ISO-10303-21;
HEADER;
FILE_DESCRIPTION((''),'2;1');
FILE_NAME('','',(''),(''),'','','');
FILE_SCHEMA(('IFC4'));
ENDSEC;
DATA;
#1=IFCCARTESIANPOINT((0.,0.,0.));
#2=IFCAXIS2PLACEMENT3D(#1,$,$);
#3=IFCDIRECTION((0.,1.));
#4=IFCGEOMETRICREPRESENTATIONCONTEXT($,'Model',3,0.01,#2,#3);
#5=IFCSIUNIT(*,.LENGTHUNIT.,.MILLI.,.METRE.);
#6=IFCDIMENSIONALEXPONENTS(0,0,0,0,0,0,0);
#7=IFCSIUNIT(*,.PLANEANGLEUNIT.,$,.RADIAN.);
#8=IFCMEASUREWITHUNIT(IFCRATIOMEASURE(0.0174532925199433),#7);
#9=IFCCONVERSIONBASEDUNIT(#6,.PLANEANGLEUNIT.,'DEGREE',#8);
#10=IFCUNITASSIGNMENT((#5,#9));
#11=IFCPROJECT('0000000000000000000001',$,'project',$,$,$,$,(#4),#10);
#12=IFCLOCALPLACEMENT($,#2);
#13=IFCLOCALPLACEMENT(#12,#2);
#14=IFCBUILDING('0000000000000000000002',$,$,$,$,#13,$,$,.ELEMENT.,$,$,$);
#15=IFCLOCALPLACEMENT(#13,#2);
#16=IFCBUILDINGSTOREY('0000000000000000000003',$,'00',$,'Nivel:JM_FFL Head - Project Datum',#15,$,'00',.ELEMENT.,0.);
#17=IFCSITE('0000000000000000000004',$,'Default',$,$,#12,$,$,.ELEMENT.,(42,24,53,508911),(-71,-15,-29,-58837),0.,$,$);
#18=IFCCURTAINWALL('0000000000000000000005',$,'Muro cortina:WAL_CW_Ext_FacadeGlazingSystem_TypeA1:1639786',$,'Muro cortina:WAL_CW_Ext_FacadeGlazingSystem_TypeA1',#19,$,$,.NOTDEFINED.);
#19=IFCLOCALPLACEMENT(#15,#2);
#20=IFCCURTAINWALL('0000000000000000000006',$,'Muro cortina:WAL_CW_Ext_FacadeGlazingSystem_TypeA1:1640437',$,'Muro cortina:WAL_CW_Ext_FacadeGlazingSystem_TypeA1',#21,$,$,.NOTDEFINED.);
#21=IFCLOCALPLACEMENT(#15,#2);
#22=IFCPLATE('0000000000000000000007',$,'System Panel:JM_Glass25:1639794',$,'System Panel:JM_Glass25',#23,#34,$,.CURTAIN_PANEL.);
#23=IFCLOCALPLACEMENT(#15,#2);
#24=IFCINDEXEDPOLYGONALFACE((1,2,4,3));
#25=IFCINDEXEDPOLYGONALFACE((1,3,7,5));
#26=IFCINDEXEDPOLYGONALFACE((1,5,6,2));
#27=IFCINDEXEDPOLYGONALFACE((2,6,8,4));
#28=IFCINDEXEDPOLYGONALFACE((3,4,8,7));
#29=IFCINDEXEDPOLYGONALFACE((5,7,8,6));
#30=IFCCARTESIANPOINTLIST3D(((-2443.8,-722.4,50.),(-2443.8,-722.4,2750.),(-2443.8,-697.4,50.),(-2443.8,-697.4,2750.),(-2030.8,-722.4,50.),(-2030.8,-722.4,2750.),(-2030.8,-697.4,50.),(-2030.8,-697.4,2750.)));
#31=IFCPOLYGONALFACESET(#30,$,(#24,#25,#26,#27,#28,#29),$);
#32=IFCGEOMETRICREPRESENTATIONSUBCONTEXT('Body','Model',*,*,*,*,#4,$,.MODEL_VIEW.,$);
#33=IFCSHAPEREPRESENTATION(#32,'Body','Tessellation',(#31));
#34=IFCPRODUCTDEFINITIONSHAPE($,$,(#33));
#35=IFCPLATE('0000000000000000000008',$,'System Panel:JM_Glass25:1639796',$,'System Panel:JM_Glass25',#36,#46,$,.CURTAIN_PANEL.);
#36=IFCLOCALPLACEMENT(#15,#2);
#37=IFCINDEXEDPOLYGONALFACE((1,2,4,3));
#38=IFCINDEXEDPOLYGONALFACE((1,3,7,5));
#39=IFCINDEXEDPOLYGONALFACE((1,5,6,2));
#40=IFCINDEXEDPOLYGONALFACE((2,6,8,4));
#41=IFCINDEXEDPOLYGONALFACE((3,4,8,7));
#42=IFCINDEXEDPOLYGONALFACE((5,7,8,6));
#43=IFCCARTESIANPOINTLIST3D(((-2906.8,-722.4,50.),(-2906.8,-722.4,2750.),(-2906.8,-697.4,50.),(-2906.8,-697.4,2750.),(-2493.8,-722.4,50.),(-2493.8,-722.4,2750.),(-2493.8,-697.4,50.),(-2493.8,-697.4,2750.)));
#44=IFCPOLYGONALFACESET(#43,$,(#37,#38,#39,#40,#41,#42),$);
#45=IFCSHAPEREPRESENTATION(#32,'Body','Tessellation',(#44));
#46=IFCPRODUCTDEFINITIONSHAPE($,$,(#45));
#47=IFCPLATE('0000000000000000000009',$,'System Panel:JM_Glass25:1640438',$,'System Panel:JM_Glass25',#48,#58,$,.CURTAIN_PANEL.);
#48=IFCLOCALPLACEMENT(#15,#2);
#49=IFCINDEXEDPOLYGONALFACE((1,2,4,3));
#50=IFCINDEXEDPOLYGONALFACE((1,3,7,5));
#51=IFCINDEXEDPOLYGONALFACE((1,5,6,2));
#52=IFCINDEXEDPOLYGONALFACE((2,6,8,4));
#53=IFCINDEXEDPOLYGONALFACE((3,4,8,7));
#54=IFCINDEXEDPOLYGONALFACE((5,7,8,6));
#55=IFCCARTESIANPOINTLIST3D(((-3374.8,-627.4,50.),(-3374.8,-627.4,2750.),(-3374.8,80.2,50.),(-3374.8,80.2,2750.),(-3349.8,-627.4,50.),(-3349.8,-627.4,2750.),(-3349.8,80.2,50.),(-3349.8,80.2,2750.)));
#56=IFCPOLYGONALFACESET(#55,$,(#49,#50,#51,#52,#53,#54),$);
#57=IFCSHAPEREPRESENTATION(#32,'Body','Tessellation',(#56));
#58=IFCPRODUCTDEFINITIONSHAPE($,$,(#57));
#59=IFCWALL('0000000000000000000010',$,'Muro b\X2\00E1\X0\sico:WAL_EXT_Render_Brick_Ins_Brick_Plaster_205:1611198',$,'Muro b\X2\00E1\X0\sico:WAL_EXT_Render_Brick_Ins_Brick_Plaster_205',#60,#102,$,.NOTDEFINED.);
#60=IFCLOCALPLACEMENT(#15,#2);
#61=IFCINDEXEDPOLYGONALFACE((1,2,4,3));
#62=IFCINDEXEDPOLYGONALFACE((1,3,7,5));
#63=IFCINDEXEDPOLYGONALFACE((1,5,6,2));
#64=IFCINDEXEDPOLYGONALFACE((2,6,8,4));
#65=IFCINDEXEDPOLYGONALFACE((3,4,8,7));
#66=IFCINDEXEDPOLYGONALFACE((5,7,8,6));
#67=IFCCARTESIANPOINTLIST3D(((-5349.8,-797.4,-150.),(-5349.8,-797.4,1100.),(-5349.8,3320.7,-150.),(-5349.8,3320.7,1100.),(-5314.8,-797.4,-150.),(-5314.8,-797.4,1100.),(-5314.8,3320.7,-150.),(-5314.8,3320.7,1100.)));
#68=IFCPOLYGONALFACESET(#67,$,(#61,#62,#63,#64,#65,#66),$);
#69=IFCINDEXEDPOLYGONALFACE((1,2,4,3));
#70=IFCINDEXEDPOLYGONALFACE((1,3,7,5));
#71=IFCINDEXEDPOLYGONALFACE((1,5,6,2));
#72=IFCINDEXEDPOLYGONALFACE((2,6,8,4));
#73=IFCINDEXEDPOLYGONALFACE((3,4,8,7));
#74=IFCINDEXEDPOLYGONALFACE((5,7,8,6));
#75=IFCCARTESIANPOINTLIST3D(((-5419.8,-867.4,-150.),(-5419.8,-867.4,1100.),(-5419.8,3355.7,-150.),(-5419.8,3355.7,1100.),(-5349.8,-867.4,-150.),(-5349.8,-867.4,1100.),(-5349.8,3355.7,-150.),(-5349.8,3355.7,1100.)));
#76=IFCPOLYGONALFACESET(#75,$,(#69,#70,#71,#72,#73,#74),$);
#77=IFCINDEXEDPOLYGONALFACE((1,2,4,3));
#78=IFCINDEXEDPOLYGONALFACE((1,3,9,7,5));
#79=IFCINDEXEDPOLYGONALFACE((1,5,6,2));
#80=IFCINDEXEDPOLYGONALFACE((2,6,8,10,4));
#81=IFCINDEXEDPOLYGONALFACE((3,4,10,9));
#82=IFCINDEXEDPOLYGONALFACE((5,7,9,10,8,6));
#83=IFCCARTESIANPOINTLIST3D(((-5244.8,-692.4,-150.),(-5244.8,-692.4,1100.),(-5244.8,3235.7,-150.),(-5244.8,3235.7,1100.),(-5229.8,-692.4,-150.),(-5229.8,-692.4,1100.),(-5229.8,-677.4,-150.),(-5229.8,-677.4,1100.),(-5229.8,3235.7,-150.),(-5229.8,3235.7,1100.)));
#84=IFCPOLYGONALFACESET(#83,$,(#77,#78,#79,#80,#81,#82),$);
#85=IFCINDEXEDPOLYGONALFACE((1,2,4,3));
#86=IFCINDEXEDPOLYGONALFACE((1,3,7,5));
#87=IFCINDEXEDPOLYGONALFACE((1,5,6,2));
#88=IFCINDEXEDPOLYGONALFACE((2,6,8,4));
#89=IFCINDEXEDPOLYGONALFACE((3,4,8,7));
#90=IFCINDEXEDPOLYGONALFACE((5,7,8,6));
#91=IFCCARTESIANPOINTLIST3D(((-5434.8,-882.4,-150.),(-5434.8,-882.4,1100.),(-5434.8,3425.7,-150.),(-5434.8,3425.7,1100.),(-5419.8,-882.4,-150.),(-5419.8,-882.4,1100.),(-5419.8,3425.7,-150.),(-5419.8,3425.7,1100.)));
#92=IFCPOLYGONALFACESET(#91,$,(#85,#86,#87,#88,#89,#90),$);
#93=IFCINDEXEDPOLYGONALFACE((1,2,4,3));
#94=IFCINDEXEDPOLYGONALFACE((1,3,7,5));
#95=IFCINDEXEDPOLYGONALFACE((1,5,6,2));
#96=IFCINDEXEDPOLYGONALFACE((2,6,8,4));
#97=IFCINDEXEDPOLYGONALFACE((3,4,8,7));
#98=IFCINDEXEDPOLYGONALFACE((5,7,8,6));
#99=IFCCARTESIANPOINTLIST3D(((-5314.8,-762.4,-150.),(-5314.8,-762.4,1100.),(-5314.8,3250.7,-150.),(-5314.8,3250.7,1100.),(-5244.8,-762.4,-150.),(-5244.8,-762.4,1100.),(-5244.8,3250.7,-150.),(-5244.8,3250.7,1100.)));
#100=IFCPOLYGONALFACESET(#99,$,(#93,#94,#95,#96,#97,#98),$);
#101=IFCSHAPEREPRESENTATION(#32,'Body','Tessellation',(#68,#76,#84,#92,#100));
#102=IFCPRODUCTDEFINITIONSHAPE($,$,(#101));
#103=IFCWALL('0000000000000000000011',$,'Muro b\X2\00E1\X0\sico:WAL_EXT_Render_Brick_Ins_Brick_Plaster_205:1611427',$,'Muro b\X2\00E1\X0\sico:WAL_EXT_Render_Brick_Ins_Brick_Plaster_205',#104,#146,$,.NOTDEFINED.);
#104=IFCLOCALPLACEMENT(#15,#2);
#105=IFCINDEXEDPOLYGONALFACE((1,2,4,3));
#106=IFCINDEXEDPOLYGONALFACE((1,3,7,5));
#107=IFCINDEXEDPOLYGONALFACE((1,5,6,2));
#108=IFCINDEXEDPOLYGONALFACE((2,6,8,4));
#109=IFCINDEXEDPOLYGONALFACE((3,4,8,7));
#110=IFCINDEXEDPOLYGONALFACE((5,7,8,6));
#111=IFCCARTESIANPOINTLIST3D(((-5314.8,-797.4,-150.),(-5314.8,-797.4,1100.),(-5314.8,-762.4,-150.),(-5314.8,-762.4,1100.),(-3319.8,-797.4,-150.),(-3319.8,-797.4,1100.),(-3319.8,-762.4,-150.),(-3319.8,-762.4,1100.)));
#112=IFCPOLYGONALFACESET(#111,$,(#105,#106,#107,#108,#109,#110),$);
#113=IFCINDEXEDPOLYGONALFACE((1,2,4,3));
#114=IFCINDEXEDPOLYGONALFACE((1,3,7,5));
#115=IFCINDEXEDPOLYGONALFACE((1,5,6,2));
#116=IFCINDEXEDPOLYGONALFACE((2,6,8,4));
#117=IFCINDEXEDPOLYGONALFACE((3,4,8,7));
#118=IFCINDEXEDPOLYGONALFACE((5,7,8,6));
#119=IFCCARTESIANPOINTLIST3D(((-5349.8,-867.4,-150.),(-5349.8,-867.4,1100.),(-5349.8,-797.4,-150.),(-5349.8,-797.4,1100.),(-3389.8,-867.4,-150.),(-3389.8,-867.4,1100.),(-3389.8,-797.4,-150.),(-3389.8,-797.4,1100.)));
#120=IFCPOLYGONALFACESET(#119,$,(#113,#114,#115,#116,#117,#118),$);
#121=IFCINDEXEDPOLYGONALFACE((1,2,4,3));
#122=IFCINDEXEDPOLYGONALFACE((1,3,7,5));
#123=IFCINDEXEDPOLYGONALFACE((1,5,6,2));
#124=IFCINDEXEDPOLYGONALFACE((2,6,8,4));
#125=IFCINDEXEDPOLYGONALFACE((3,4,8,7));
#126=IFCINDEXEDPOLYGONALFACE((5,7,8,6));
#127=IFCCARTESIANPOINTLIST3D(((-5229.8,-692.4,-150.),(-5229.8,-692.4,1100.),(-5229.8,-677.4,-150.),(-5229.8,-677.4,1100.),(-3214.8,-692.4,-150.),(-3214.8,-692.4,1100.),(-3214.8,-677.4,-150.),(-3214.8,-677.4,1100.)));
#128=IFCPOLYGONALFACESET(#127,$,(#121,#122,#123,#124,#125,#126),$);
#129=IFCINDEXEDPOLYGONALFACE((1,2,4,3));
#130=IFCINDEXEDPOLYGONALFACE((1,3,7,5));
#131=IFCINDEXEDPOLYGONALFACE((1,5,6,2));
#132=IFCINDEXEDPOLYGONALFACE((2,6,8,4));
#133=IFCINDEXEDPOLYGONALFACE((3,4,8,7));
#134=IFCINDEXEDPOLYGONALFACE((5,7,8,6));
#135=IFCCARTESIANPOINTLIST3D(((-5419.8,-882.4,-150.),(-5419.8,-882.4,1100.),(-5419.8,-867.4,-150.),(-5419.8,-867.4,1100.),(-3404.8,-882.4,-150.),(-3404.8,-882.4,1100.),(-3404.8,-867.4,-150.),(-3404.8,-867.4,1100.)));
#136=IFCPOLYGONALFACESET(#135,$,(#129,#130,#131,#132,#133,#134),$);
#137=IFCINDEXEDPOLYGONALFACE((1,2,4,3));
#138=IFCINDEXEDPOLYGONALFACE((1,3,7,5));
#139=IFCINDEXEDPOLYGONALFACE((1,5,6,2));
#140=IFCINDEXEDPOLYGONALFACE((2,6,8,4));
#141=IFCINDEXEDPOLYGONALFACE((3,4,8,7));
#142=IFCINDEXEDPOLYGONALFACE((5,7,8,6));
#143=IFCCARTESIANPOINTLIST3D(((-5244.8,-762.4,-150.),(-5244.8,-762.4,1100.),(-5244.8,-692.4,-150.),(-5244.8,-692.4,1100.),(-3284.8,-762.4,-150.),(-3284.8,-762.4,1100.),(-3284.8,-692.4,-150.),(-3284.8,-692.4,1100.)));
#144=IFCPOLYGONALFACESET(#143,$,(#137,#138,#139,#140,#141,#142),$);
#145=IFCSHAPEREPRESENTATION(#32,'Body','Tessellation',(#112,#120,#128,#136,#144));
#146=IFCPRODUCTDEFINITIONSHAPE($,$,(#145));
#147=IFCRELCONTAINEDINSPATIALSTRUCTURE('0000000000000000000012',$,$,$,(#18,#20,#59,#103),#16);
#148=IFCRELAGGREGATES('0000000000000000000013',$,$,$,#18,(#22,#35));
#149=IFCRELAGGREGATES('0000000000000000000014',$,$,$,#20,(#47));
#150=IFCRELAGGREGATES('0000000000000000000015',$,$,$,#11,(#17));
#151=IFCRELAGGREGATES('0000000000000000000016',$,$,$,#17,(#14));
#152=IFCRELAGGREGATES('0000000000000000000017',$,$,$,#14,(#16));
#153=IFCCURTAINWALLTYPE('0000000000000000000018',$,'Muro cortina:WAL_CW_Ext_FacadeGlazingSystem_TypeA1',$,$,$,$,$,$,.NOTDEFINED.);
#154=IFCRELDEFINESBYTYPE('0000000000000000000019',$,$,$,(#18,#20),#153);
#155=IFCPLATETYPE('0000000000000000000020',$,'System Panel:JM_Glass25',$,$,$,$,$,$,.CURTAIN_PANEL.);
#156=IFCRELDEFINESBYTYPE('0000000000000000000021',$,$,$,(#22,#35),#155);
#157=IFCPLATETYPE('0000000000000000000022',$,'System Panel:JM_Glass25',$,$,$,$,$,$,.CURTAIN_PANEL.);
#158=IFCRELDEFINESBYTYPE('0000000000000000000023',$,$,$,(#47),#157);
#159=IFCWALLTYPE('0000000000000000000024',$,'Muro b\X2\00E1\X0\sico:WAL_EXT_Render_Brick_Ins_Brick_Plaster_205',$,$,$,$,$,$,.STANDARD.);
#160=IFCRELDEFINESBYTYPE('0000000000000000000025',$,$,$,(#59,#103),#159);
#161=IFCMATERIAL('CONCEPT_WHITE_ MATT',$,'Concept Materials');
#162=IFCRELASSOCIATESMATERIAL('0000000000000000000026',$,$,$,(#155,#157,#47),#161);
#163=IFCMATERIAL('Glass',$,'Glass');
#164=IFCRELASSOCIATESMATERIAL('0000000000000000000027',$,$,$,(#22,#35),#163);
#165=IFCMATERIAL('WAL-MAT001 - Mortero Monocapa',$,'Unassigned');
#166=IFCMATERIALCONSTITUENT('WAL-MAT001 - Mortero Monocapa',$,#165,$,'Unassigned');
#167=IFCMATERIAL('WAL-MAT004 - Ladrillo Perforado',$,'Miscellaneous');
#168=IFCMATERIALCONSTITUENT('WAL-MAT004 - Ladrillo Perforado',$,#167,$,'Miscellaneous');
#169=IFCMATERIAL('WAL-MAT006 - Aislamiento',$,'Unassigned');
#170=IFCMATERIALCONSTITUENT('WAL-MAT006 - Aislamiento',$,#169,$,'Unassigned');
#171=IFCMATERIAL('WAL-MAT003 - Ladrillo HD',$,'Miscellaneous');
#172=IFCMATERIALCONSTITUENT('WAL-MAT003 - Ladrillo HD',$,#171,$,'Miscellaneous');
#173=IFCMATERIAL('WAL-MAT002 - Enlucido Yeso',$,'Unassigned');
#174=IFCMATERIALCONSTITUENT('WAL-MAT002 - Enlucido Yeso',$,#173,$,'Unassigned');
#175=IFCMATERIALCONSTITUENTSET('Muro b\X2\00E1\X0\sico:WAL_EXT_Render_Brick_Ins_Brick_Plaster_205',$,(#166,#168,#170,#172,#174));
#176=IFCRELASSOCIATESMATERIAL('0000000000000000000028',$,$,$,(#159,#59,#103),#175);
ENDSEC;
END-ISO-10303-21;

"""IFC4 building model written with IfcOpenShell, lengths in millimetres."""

from ifc_helpers import new_model, entity, si_unit, converted_unit, direction, frame, origin, place, context, subcontext, project, spatial, indexed_curve, outline, extrude, source, transform, mapped, material, constituent, constituent_set, type_object, type_shapes, element, aggregate, save


model = new_model("IFC4")

# Units and contexts
model_context = context("Model", 3, precision=0.01, world=origin(), true_north=direction((0.0, 1.0)))
body_context = subcontext(model_context, "Body", "Model", "MODEL_VIEW")
ifc_project = project(units=[si_unit("LENGTHUNIT", "METRE", prefix="MILLI"), converted_unit("PLANEANGLEUNIT", "DEGREE", entity("IfcRatioMeasure", 0.0174532925199433), si_unit("PLANEANGLEUNIT", "RADIAN"), dimensions=[0, 0, 0, 0, 0, 0, 0])], contexts=[model_context])

# Site, building, storey
site_placement = place(None, origin())
site = spatial("IfcSite", under=ifc_project, at=site_placement, Name="Default", CompositionType="ELEMENT", RefLatitude=(42, 24, 53, 508911), RefLongitude=(-71, -15, -29, -58837), RefElevation=0.0)
building_placement = place(site_placement, origin())
building = spatial("IfcBuilding", under=site, at=building_placement, CompositionType="ELEMENT")
storey_placement = place(building_placement, origin())
storey = spatial("IfcBuildingStorey", under=building, at=storey_placement, Name="00", ObjectType="Nivel:JM_FFL Head - Project Datum", LongName="00", CompositionType="ELEMENT", Elevation=0.0)

# Curtain wall
curtain_wall_type = type_object("IfcCurtainWallType", Name="Muro cortina:WAL_CW_Ext_FacadeGlazingSystem_TypeA1", PredefinedType="NOTDEFINED")
curtain_wall_1_placement = place(storey_placement, origin())
curtain_wall_1 = element("IfcCurtainWall", 1, at=curtain_wall_1_placement, inside=storey, type_object=curtain_wall_type, Name="Muro cortina:WAL_CW_Ext_FacadeGlazingSystem_TypeA1:1639786", ObjectType="Muro cortina:WAL_CW_Ext_FacadeGlazingSystem_TypeA1", PredefinedType="NOTDEFINED")

# Curtain wall
curtain_wall_2_placement = place(storey_placement, origin())
curtain_wall_2 = element("IfcCurtainWall", 2, at=curtain_wall_2_placement, inside=storey, type_object=curtain_wall_type, Name="Muro cortina:WAL_CW_Ext_FacadeGlazingSystem_TypeA1:1640437", ObjectType="Muro cortina:WAL_CW_Ext_FacadeGlazingSystem_TypeA1", PredefinedType="NOTDEFINED")

# Plates
ifc_material_1 = material(Name="Glass", Category="Glass")
ifc_material_2 = material(Name="CONCEPT_WHITE_ MATT", Category="Concept Materials")
plate_type_1 = type_object("IfcPlateType", Name="System Panel:JM_Glass25", PredefinedType="CURTAIN_PANEL", material=ifc_material_2)
shared_shape_1 = source(origin(), body_context, "Body", "SweptSolid", [
    extrude(outline(indexed_curve([(-12.5, -206.5), (12.5, -206.5), (12.5, 206.5), (-12.5, 206.5), (-12.5, -206.5)], self_intersect=False)), frame((0.0, 32.5, 0.0), z_axis=(0.0, 0.0, 1.0), x_axis=(0.0, 1.0, 0.0)), (0.0, 0.0, 1.0), 2700.0),
])
type_shapes(plate_type_1, [shared_shape_1])
plate_1_placement = place(curtain_wall_1_placement, frame((-2237.3, -677.4, 50.0), z_axis=(0.0, 0.0, 1.0), x_axis=(-1.0, 0.0, 0.0)))
plate_1 = element("IfcPlate", 3, at=plate_1_placement, type_object=plate_type_1, material=ifc_material_1, Name="System Panel:JM_Glass25:1639794", ObjectType="System Panel:JM_Glass25", PredefinedType="CURTAIN_PANEL", context=body_context, shape_type="MappedRepresentation", body=[
    mapped(shared_shape_1, transform((0.0, 0.0, 0.0), scale=1.0)),
])
plate_2_placement = place(curtain_wall_1_placement, frame((-2700.3, -677.4, 50.0), z_axis=(0.0, 0.0, 1.0), x_axis=(-1.0, 0.0, 0.0)))
plate_2 = element("IfcPlate", 4, at=plate_2_placement, type_object=plate_type_1, material=ifc_material_1, Name="System Panel:JM_Glass25:1639796", ObjectType="System Panel:JM_Glass25", PredefinedType="CURTAIN_PANEL", context=body_context, shape_type="MappedRepresentation", body=[
    mapped(shared_shape_1, transform((0.0, 0.0, 0.0), scale=1.0)),
])
aggregate(curtain_wall_1, [plate_1, plate_2])
plate_type_2 = type_object("IfcPlateType", Name="System Panel:JM_Glass25", PredefinedType="CURTAIN_PANEL", material=ifc_material_2)
shared_shape_2 = source(origin(), body_context, "Body", "SweptSolid", [
    extrude(outline(indexed_curve([(-12.5, -353.8), (12.5, -353.8), (12.5, 353.8), (-12.5, 353.8), (-12.5, -353.8)], self_intersect=False)), frame((0.0, 32.5, 0.0), z_axis=(0.0, 0.0, 1.0), x_axis=(0.0, 1.0, 0.0)), (0.0, 0.0, 1.0), 2700.0),
])
type_shapes(plate_type_2, [shared_shape_2])
plate_3_placement = place(curtain_wall_2_placement, frame((-3329.8, -273.6, 50.0), z_axis=(0.0, 0.0, 1.0), x_axis=(0.0, 1.0, 0.0)))
plate_3 = element("IfcPlate", 5, at=plate_3_placement, type_object=plate_type_2, material=ifc_material_2, Name="System Panel:JM_Glass25:1640438", ObjectType="System Panel:JM_Glass25", PredefinedType="CURTAIN_PANEL", context=body_context, shape_type="MappedRepresentation", body=[
    mapped(shared_shape_2, transform((0.0, 0.0, 0.0), scale=1.0)),
])
aggregate(curtain_wall_2, [plate_3])

# Walls
ifc_material_3 = material(Name="WAL-MAT001 - Mortero Monocapa", Category="Unassigned")
ifc_constituent_1 = constituent(ifc_material_3, Name="WAL-MAT001 - Mortero Monocapa", Category="Unassigned")
ifc_material_4 = material(Name="WAL-MAT004 - Ladrillo Perforado", Category="Miscellaneous")
ifc_constituent_2 = constituent(ifc_material_4, Name="WAL-MAT004 - Ladrillo Perforado", Category="Miscellaneous")
ifc_material_5 = material(Name="WAL-MAT006 - Aislamiento", Category="Unassigned")
ifc_constituent_3 = constituent(ifc_material_5, Name="WAL-MAT006 - Aislamiento", Category="Unassigned")
ifc_material_6 = material(Name="WAL-MAT003 - Ladrillo HD", Category="Miscellaneous")
ifc_constituent_4 = constituent(ifc_material_6, Name="WAL-MAT003 - Ladrillo HD", Category="Miscellaneous")
ifc_material_7 = material(Name="WAL-MAT002 - Enlucido Yeso", Category="Unassigned")
ifc_constituent_5 = constituent(ifc_material_7, Name="WAL-MAT002 - Enlucido Yeso", Category="Unassigned")
ifc_constituent_set = constituent_set(constituents=[ifc_constituent_1, ifc_constituent_2, ifc_constituent_3, ifc_constituent_4, ifc_constituent_5], Name="Muro básico:WAL_EXT_Render_Brick_Ins_Brick_Plaster_205")
wall_type = type_object("IfcWallType", Name="Muro básico:WAL_EXT_Render_Brick_Ins_Brick_Plaster_205", PredefinedType="STANDARD", material=ifc_constituent_set)
wall_1_placement = place(storey_placement, frame((-5332.3, -882.4, -150.0), z_axis=(0.0, 0.0, 1.0), x_axis=(0.0, 1.0, 0.0)))
element("IfcWall", 6, at=wall_1_placement, inside=storey, type_object=wall_type, material=ifc_constituent_set, Name="Muro básico:WAL_EXT_Render_Brick_Ins_Brick_Plaster_205:1611198", ObjectType="Muro básico:WAL_EXT_Render_Brick_Ins_Brick_Plaster_205", PredefinedType="NOTDEFINED", context=body_context, shape_type="SweptSolid", body=[
    extrude(outline(indexed_curve([(-2059.0, -17.5), (2059.0, -17.5), (2059.0, 17.5), (-2059.0, 17.5), (-2059.0, -17.5)], self_intersect=False)), frame((2144.0, 0.0, 0.0)), (0.0, 0.0, 1.0), 1250.0),
    extrude(outline(indexed_curve([(-2111.5, -35.0), (2111.5, -35.0), (2111.5, 35.0), (-2111.5, 35.0), (-2111.5, -35.0)], self_intersect=False)), frame((2126.5, 52.5, 0.0)), (0.0, 0.0, 1.0), 1250.0),
    extrude(outline(indexed_curve([(-1559.2, -6.0), (2353.8, -6.0), (2353.8, 9.0), (-1574.2, 9.0), (-1574.2, -6.0), (-1559.2, -6.0)], self_intersect=False)), frame((1764.2, -96.5, 0.0)), (0.0, 0.0, 1.0), 1250.0),
    extrude(outline(indexed_curve([(-7.5, -2154.0), (7.5, -2154.0), (7.5, 2154.0), (-7.5, 2154.0), (-7.5, -2154.0)], self_intersect=False)), frame((2154.0, 95.0, 0.0), z_axis=(0.0, 0.0, 1.0), x_axis=(0.0, -1.0, 0.0)), (0.0, 0.0, 1.0), 1250.0),
    extrude(outline(indexed_curve([(-2006.5, -35.0), (2006.5, -35.0), (2006.5, 35.0), (-2006.5, 35.0), (-2006.5, -35.0)], self_intersect=False)), frame((2126.5, -52.5, 0.0)), (0.0, 0.0, 1.0), 1250.0),
])
wall_2_placement = place(storey_placement, frame((-5229.8, -779.9, -150.0)))
element("IfcWall", 7, at=wall_2_placement, inside=storey, type_object=wall_type, material=ifc_constituent_set, Name="Muro básico:WAL_EXT_Render_Brick_Ins_Brick_Plaster_205:1611427", ObjectType="Muro básico:WAL_EXT_Render_Brick_Ins_Brick_Plaster_205", PredefinedType="NOTDEFINED", context=body_context, shape_type="SweptSolid", body=[
    extrude(outline(indexed_curve([(-997.5, -17.5), (997.5, -17.5), (997.5, 17.5), (-997.5, 17.5), (-997.5, -17.5)], self_intersect=False)), frame((912.5, 0.0, 0.0)), (0.0, 0.0, 1.0), 1250.0),
    extrude(outline(indexed_curve([(-980.0, -35.0), (980.0, -35.0), (980.0, 35.0), (-980.0, 35.0), (-980.0, -35.0)], self_intersect=False)), frame((860.0, -52.5, 0.0)), (0.0, 0.0, 1.0), 1250.0),
    extrude(outline(indexed_curve([(-7.5, -1007.5), (7.5, -1007.5), (7.5, 1007.5), (-7.5, 1007.5), (-7.5, -1007.5)], self_intersect=False)), frame((1007.5, 95.0, 0.0), z_axis=(0.0, 0.0, 1.0), x_axis=(0.0, -1.0, 0.0)), (0.0, 0.0, 1.0), 1250.0),
    extrude(outline(indexed_curve([(-7.5, -1007.5), (7.5, -1007.5), (7.5, 1007.5), (-7.5, 1007.5), (-7.5, -1007.5)], self_intersect=False)), frame((817.5, -95.0, 0.0), z_axis=(0.0, 0.0, 1.0), x_axis=(0.0, 1.0, 0.0)), (0.0, 0.0, 1.0), 1250.0),
    extrude(outline(indexed_curve([(-980.0, -35.0), (980.0, -35.0), (980.0, 35.0), (-980.0, 35.0), (-980.0, -35.0)], self_intersect=False)), frame((965.0, 52.5, 0.0)), (0.0, 0.0, 1.0), 1250.0),
])

save(model, "model.ifc")
